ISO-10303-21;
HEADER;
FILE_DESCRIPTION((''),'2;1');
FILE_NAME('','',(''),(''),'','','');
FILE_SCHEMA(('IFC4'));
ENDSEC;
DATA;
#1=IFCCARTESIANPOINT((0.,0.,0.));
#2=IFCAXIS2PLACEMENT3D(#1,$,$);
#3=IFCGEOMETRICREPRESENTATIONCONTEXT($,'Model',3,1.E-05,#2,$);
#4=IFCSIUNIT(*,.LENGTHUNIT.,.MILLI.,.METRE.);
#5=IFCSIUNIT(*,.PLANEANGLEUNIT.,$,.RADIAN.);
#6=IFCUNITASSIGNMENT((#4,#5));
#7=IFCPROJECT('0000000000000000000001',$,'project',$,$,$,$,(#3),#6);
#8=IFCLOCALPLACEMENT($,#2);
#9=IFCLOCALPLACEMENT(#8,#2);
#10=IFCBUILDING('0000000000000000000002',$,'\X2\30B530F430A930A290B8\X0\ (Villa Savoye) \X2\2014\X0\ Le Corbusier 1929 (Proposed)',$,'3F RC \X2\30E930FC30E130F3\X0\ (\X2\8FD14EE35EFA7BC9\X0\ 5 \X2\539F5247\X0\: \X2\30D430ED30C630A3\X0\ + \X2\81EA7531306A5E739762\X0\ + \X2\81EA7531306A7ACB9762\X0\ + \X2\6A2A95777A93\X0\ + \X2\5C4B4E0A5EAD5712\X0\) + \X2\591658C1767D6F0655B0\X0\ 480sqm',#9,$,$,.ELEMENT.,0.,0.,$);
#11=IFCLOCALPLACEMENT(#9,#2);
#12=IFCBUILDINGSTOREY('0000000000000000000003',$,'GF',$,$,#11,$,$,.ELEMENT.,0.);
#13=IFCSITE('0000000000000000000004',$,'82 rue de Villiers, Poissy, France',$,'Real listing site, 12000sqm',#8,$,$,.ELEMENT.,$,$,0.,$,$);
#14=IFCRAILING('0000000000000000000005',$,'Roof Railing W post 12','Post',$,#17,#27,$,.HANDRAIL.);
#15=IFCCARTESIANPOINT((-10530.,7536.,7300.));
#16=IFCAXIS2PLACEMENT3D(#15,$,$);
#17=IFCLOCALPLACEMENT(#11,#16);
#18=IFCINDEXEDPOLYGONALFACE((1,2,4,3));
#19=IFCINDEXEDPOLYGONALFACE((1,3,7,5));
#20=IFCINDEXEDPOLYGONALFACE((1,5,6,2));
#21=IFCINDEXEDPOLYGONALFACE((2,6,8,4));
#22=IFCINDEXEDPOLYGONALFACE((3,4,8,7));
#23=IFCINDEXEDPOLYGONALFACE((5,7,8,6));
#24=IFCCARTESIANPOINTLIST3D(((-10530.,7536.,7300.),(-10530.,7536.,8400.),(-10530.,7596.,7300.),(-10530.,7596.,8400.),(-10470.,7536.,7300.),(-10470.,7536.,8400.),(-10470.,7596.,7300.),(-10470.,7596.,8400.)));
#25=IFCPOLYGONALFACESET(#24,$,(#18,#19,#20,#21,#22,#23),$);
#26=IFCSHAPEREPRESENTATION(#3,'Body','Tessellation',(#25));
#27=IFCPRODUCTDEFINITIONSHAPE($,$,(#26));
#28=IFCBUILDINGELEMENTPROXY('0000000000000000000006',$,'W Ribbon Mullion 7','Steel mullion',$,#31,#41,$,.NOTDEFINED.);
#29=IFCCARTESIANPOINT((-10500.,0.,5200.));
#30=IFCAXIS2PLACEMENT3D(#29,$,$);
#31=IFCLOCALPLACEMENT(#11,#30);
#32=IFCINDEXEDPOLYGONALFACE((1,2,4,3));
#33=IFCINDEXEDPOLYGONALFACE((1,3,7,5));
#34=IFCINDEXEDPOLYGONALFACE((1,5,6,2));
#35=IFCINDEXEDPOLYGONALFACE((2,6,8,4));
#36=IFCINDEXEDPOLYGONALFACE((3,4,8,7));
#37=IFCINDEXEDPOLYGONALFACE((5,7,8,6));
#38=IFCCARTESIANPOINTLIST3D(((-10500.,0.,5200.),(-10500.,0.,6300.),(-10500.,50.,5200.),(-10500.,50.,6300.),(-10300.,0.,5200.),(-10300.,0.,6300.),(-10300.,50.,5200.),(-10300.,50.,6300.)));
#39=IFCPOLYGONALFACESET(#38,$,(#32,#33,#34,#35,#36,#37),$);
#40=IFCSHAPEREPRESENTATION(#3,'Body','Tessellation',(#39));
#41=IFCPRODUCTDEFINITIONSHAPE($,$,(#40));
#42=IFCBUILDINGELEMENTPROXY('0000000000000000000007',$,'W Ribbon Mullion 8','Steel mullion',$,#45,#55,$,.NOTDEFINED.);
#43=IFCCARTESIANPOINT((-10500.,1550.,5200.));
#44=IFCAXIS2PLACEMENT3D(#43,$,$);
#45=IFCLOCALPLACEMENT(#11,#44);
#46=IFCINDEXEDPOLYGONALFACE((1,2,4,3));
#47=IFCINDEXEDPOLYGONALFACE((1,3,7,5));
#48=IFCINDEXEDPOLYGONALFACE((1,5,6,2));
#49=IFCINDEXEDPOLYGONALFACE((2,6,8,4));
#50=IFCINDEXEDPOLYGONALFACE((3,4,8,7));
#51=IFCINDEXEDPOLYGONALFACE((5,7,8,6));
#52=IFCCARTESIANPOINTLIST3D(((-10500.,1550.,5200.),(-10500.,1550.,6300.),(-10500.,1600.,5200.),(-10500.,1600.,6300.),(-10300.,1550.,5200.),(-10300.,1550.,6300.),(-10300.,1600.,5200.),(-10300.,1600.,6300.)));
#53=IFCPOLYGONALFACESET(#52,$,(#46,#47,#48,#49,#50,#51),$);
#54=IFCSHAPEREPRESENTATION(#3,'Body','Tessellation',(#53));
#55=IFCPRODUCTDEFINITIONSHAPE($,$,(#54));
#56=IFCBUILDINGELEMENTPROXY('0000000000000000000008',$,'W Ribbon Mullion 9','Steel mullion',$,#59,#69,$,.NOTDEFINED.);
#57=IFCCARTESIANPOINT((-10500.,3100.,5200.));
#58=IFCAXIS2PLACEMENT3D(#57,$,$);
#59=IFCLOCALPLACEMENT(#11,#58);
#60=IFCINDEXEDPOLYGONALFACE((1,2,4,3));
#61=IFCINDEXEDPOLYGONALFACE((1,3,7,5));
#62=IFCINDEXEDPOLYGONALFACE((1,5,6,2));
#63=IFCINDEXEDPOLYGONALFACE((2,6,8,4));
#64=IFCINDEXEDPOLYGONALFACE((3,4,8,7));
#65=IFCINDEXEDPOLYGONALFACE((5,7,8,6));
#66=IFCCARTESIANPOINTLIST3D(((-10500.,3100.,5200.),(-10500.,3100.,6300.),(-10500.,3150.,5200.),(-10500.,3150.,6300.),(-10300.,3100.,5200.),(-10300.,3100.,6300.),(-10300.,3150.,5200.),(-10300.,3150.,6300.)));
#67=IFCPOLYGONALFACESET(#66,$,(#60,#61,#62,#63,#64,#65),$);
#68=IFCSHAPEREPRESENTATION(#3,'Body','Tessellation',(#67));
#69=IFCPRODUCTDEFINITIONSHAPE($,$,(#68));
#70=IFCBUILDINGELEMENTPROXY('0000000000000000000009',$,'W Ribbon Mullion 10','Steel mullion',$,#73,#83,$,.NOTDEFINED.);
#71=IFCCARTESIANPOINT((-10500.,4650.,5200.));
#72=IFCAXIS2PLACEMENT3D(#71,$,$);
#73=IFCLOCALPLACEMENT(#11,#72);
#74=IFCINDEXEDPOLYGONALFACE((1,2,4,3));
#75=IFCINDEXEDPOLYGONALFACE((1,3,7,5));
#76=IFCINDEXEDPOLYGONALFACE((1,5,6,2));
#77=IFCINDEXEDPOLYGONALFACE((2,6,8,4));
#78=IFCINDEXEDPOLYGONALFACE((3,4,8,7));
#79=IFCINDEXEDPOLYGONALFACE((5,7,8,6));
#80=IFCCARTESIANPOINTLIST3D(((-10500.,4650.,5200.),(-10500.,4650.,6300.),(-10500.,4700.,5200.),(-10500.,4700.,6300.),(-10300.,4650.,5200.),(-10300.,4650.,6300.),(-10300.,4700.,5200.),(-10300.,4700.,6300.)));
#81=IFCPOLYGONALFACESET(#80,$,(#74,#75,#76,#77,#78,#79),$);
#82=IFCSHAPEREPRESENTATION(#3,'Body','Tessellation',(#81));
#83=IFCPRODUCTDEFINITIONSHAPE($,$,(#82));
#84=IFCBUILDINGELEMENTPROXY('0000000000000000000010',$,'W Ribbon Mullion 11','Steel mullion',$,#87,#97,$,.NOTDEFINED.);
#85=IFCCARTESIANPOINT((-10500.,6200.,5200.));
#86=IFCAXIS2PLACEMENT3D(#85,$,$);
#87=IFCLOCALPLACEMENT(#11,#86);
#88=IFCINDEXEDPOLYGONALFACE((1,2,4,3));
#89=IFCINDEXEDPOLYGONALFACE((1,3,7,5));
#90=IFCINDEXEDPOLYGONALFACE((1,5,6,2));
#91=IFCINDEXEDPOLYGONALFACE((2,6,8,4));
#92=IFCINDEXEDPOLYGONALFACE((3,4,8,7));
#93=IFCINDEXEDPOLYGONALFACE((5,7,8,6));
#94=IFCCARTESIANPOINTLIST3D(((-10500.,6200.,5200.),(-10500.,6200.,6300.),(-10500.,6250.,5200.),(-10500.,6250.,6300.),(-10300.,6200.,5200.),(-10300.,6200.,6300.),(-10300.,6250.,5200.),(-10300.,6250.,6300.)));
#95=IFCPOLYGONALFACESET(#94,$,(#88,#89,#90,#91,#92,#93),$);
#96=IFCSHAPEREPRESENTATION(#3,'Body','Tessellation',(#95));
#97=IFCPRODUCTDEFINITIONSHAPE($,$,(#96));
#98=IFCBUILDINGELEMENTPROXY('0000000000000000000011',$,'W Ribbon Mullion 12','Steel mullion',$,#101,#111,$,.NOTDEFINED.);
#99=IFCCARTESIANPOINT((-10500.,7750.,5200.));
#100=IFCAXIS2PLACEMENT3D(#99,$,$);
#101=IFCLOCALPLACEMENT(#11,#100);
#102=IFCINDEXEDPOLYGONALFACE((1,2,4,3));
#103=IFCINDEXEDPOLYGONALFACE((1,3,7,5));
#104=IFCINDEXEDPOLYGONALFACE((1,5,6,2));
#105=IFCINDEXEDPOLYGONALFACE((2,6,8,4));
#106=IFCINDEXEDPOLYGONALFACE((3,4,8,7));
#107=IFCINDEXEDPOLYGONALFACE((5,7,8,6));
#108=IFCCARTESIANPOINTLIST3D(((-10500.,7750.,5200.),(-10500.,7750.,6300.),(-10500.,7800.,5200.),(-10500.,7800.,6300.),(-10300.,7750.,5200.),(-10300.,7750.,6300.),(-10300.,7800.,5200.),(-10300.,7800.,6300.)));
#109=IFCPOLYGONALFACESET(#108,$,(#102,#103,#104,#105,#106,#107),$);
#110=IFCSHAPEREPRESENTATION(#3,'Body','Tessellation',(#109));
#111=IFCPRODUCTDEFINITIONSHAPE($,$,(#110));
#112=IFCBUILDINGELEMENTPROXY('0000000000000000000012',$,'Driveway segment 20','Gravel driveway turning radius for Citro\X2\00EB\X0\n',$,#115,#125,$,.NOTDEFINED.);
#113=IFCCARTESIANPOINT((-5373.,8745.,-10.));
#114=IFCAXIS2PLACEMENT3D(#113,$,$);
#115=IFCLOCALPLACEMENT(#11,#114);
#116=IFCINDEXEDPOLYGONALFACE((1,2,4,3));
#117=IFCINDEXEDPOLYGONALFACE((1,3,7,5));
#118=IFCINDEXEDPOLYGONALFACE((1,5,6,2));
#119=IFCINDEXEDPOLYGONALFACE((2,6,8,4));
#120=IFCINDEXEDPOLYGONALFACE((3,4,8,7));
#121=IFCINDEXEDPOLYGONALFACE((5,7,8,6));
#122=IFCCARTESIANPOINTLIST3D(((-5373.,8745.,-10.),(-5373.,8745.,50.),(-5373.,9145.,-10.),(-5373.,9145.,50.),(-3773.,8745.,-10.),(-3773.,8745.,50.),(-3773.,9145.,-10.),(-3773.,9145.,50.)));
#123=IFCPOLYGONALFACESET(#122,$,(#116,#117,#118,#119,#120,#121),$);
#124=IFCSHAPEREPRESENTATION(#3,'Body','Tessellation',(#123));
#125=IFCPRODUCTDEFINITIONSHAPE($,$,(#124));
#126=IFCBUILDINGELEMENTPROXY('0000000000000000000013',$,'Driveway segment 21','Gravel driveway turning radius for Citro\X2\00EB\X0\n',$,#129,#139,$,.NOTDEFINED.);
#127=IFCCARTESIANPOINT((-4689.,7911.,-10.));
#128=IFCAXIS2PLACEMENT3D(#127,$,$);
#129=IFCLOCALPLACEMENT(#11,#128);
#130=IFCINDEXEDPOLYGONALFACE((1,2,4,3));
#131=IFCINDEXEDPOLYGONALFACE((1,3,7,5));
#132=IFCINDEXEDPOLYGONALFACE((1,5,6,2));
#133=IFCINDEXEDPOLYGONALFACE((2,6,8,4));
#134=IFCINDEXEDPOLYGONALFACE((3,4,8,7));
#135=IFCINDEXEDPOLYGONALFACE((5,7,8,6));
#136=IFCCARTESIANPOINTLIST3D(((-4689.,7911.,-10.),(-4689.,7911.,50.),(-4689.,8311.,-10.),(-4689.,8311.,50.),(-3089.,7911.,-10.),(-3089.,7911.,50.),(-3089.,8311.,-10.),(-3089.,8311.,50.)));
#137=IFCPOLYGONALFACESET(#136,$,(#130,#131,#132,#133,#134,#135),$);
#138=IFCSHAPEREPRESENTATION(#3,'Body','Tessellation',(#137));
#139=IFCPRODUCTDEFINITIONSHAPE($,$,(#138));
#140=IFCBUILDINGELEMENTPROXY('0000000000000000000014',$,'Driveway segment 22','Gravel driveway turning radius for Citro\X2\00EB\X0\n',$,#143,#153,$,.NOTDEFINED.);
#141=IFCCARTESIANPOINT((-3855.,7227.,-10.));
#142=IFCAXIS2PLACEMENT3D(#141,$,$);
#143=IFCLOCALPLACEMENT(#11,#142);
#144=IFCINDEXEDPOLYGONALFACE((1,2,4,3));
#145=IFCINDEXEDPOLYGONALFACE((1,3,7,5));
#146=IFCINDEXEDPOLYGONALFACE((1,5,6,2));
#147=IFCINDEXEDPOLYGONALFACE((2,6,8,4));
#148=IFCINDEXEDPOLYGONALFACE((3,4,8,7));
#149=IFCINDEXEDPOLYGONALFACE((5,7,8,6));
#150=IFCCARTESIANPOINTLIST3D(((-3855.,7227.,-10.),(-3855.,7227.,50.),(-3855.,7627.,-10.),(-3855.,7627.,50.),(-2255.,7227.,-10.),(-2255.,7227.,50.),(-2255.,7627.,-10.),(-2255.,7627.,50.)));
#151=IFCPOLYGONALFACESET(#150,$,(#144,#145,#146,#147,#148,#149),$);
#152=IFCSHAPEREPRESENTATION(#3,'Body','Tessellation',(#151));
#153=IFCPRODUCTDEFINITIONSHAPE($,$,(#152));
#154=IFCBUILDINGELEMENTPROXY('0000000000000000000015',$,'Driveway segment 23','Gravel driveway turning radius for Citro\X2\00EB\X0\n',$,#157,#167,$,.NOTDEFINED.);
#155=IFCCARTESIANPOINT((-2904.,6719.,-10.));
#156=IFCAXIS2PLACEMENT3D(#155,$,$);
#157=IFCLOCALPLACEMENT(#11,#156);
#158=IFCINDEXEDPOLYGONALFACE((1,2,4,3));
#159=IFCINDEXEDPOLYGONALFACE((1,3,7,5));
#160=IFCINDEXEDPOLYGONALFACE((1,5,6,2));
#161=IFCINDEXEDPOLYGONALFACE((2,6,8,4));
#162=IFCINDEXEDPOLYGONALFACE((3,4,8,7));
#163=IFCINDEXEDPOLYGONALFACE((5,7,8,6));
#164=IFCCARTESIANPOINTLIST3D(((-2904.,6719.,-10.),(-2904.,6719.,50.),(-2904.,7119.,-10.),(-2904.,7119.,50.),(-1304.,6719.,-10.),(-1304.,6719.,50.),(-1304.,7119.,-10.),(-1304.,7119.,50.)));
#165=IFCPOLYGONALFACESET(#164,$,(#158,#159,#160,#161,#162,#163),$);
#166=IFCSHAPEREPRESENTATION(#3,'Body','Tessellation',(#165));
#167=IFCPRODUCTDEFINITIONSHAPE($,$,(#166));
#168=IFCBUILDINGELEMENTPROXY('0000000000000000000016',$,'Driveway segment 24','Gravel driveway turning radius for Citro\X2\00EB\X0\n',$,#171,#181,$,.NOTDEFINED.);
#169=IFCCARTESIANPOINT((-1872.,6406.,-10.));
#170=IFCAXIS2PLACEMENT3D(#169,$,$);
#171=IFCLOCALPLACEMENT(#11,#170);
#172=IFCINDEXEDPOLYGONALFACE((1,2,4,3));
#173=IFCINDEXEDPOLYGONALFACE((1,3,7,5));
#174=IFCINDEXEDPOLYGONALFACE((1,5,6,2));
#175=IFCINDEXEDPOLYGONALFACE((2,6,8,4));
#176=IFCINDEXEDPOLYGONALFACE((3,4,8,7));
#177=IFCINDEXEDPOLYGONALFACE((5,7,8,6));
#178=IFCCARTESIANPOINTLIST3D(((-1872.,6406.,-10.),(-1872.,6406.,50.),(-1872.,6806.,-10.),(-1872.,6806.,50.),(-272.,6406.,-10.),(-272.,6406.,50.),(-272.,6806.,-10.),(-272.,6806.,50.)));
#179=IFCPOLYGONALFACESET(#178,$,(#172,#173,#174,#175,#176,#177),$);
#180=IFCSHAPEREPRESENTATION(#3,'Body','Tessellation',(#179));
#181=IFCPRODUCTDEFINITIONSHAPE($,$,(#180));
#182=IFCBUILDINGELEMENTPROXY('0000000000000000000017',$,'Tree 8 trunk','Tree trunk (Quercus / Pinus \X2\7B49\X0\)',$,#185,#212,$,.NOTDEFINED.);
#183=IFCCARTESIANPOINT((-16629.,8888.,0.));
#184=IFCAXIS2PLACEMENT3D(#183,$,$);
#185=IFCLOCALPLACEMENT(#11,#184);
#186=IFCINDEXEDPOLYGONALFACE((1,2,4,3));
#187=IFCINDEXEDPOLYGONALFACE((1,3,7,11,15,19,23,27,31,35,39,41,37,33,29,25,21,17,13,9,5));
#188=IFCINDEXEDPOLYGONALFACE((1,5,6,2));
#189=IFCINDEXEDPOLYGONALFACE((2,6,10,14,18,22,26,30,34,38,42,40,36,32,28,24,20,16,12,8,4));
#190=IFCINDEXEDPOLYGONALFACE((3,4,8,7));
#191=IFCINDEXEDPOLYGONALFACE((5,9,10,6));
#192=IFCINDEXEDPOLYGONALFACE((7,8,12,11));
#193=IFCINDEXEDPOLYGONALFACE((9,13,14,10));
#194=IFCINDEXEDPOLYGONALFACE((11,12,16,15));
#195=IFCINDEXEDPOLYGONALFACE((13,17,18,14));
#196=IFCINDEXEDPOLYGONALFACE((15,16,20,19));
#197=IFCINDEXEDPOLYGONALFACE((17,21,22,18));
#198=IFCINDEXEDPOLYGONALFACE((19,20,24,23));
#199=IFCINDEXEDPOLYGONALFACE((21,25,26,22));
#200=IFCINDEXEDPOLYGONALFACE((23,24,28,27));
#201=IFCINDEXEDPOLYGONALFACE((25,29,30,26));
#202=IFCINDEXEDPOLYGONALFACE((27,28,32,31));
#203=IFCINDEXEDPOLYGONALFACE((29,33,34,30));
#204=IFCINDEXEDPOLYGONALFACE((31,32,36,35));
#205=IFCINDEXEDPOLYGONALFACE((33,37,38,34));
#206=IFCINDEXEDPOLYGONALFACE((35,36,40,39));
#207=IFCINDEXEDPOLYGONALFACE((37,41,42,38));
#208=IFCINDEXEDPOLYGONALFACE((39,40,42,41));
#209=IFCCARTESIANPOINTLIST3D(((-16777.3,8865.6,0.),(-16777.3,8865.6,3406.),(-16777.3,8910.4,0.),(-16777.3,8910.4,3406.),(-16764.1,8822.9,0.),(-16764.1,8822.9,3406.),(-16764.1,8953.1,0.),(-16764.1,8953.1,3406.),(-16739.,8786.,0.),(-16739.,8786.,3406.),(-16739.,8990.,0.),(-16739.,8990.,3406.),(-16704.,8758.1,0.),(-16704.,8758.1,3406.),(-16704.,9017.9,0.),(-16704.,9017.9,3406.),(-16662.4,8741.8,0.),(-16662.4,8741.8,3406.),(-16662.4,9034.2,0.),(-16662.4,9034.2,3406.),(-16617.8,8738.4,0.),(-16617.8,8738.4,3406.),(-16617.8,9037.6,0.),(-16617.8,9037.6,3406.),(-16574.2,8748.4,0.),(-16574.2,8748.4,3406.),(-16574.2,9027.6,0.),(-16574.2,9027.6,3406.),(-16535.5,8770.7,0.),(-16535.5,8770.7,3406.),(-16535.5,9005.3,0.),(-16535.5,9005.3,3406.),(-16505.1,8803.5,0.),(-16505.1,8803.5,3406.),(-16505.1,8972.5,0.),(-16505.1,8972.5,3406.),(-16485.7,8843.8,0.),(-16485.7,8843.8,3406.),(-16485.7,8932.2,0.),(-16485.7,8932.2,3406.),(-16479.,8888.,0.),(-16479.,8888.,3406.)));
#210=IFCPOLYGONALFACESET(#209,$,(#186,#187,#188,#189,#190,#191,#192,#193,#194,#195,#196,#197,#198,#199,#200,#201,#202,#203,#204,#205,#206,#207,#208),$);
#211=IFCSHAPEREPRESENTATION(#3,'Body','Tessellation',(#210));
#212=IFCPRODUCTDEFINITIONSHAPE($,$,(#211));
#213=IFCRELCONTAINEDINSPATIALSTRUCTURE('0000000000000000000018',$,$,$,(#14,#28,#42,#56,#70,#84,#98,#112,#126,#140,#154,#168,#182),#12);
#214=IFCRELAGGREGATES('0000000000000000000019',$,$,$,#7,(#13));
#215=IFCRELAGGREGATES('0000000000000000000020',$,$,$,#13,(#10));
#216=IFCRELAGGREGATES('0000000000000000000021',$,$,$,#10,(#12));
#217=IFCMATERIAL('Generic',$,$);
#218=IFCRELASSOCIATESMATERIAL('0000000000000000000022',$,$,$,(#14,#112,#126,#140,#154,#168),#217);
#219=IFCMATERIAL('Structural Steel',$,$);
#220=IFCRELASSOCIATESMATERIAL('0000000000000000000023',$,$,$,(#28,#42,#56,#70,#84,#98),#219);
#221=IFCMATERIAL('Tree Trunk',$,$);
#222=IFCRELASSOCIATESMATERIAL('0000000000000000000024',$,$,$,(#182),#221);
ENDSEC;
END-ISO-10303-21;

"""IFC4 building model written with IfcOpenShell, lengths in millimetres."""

from ifc_helpers import new_model, si_unit, frame, frame_2d, origin, origin_2d, place, context, project, spatial, rectangle, circle, extrude, material, element, save


model = new_model("IFC4")

# Units and contexts
model_context = context("Model", 3, precision=1e-05, world=origin())
ifc_project = project(units=[si_unit("LENGTHUNIT", "METRE", prefix="MILLI"), si_unit("PLANEANGLEUNIT", "RADIAN")], contexts=[model_context])

# Site, building, storey
site_placement = place(None, origin())
site = spatial("IfcSite", under=ifc_project, at=site_placement, Name="82 rue de Villiers, Poissy, France", ObjectType="Real listing site, 12000sqm", CompositionType="ELEMENT", RefElevation=0.0)
building_placement = place(site_placement, origin())
building = spatial("IfcBuilding", under=site, at=building_placement, Name="サヴォア邸 (Villa Savoye) — Le Corbusier 1929 (Proposed)", ObjectType="3F RC ラーメン (近代建築 5 原則: ピロティ + 自由な平面 + 自由な立面 + 横長窓 + 屋上庭園) + 外壁白漆喰 480sqm", CompositionType="ELEMENT", ElevationOfRefHeight=0.0, ElevationOfTerrain=0.0)
storey_placement = place(building_placement, origin())
storey = spatial("IfcBuildingStorey", under=building, at=storey_placement, Name="GF", CompositionType="ELEMENT", Elevation=0.0)

# Shared definitions
ifc_material_1 = material(Name="Generic")

# Railing
railing_1_placement = place(storey_placement, frame((-10530.0, 7536.0, 7300.0)))
element("IfcRailing", 1, at=railing_1_placement, inside=storey, material=ifc_material_1, Name="Roof Railing W post 12", Description="Post", PredefinedType="HANDRAIL", context=model_context, shape_type="SweptSolid", body=[
    extrude(rectangle(XDim=60.0, YDim=60.0, at=frame_2d((30.0, 30.0))), frame((-10530.0, 7536.0, 7300.0)), (0.0, 0.0, 1.0), 1100.0),
])

# Building element proxies
ifc_material_2 = material(Name="Structural Steel")
proxy_1_placement = place(storey_placement, frame((-10500.0, 0.0, 5200.0)))
element("IfcBuildingElementProxy", 2, at=proxy_1_placement, inside=storey, material=ifc_material_2, Name="W Ribbon Mullion 7", Description="Steel mullion", PredefinedType="NOTDEFINED", context=model_context, shape_type="SweptSolid", body=[
    extrude(rectangle(XDim=200.0, YDim=50.0, at=frame_2d((100.0, 25.0))), frame((-10500.0, 0.0, 5200.0)), (0.0, 0.0, 1.0), 1100.0),
])
proxy_2_placement = place(storey_placement, frame((-10500.0, 1550.0, 5200.0)))
element("IfcBuildingElementProxy", 3, at=proxy_2_placement, inside=storey, material=ifc_material_2, Name="W Ribbon Mullion 8", Description="Steel mullion", PredefinedType="NOTDEFINED", context=model_context, shape_type="SweptSolid", body=[
    extrude(rectangle(XDim=200.0, YDim=50.0, at=frame_2d((100.0, 25.0))), frame((-10500.0, 1550.0, 5200.0)), (0.0, 0.0, 1.0), 1100.0),
])
proxy_3_placement = place(storey_placement, frame((-10500.0, 3100.0, 5200.0)))
element("IfcBuildingElementProxy", 4, at=proxy_3_placement, inside=storey, material=ifc_material_2, Name="W Ribbon Mullion 9", Description="Steel mullion", PredefinedType="NOTDEFINED", context=model_context, shape_type="SweptSolid", body=[
    extrude(rectangle(XDim=200.0, YDim=50.0, at=frame_2d((100.0, 25.0))), frame((-10500.0, 3100.0, 5200.0)), (0.0, 0.0, 1.0), 1100.0),
])
proxy_4_placement = place(storey_placement, frame((-10500.0, 4650.0, 5200.0)))
element("IfcBuildingElementProxy", 5, at=proxy_4_placement, inside=storey, material=ifc_material_2, Name="W Ribbon Mullion 10", Description="Steel mullion", PredefinedType="NOTDEFINED", context=model_context, shape_type="SweptSolid", body=[
    extrude(rectangle(XDim=200.0, YDim=50.0, at=frame_2d((100.0, 25.0))), frame((-10500.0, 4650.0, 5200.0)), (0.0, 0.0, 1.0), 1100.0),
])
proxy_5_placement = place(storey_placement, frame((-10500.0, 6200.0, 5200.0)))
element("IfcBuildingElementProxy", 6, at=proxy_5_placement, inside=storey, material=ifc_material_2, Name="W Ribbon Mullion 11", Description="Steel mullion", PredefinedType="NOTDEFINED", context=model_context, shape_type="SweptSolid", body=[
    extrude(rectangle(XDim=200.0, YDim=50.0, at=frame_2d((100.0, 25.0))), frame((-10500.0, 6200.0, 5200.0)), (0.0, 0.0, 1.0), 1100.0),
])
proxy_6_placement = place(storey_placement, frame((-10500.0, 7750.0, 5200.0)))
element("IfcBuildingElementProxy", 7, at=proxy_6_placement, inside=storey, material=ifc_material_2, Name="W Ribbon Mullion 12", Description="Steel mullion", PredefinedType="NOTDEFINED", context=model_context, shape_type="SweptSolid", body=[
    extrude(rectangle(XDim=200.0, YDim=50.0, at=frame_2d((100.0, 25.0))), frame((-10500.0, 7750.0, 5200.0)), (0.0, 0.0, 1.0), 1100.0),
])
proxy_7_placement = place(storey_placement, frame((-5373.0, 8745.0, -10.0)))
element("IfcBuildingElementProxy", 8, at=proxy_7_placement, inside=storey, material=ifc_material_1, Name="Driveway segment 20", Description="Gravel driveway turning radius for Citroën", PredefinedType="NOTDEFINED", context=model_context, shape_type="SweptSolid", body=[
    extrude(rectangle(XDim=1600.0, YDim=400.0, at=frame_2d((800.0, 200.0))), frame((-5373.0, 8745.0, -10.0)), (0.0, 0.0, 1.0), 60.0),
])
proxy_8_placement = place(storey_placement, frame((-4689.0, 7911.0, -10.0)))
element("IfcBuildingElementProxy", 9, at=proxy_8_placement, inside=storey, material=ifc_material_1, Name="Driveway segment 21", Description="Gravel driveway turning radius for Citroën", PredefinedType="NOTDEFINED", context=model_context, shape_type="SweptSolid", body=[
    extrude(rectangle(XDim=1600.0, YDim=400.0, at=frame_2d((800.0, 200.0))), frame((-4689.0, 7911.0, -10.0)), (0.0, 0.0, 1.0), 60.0),
])
proxy_9_placement = place(storey_placement, frame((-3855.0, 7227.0, -10.0)))
element("IfcBuildingElementProxy", 10, at=proxy_9_placement, inside=storey, material=ifc_material_1, Name="Driveway segment 22", Description="Gravel driveway turning radius for Citroën", PredefinedType="NOTDEFINED", context=model_context, shape_type="SweptSolid", body=[
    extrude(rectangle(XDim=1600.0, YDim=400.0, at=frame_2d((800.0, 200.0))), frame((-3855.0, 7227.0, -10.0)), (0.0, 0.0, 1.0), 60.0),
])
proxy_10_placement = place(storey_placement, frame((-2904.0, 6719.0, -10.0)))
element("IfcBuildingElementProxy", 11, at=proxy_10_placement, inside=storey, material=ifc_material_1, Name="Driveway segment 23", Description="Gravel driveway turning radius for Citroën", PredefinedType="NOTDEFINED", context=model_context, shape_type="SweptSolid", body=[
    extrude(rectangle(XDim=1600.0, YDim=400.0, at=frame_2d((800.0, 200.0))), frame((-2904.0, 6719.0, -10.0)), (0.0, 0.0, 1.0), 60.0),
])
proxy_11_placement = place(storey_placement, frame((-1872.0, 6406.0, -10.0)))
element("IfcBuildingElementProxy", 12, at=proxy_11_placement, inside=storey, material=ifc_material_1, Name="Driveway segment 24", Description="Gravel driveway turning radius for Citroën", PredefinedType="NOTDEFINED", context=model_context, shape_type="SweptSolid", body=[
    extrude(rectangle(XDim=1600.0, YDim=400.0, at=frame_2d((800.0, 200.0))), frame((-1872.0, 6406.0, -10.0)), (0.0, 0.0, 1.0), 60.0),
])
ifc_material_3 = material(Name="Tree Trunk")
proxy_12_placement = place(storey_placement, frame((-16629.0, 8888.0, 0.0)))
element("IfcBuildingElementProxy", 13, at=proxy_12_placement, inside=storey, material=ifc_material_3, Name="Tree 8 trunk", Description="Tree trunk (Quercus / Pinus 等)", PredefinedType="NOTDEFINED", context=model_context, shape_type="SweptSolid", body=[
    extrude(circle(Radius=150.0, at=origin_2d()), frame((-16629.0, 8888.0, 0.0)), (0.0, 0.0, 1.0), 3406.0),
])

save(model, "model.ifc")
